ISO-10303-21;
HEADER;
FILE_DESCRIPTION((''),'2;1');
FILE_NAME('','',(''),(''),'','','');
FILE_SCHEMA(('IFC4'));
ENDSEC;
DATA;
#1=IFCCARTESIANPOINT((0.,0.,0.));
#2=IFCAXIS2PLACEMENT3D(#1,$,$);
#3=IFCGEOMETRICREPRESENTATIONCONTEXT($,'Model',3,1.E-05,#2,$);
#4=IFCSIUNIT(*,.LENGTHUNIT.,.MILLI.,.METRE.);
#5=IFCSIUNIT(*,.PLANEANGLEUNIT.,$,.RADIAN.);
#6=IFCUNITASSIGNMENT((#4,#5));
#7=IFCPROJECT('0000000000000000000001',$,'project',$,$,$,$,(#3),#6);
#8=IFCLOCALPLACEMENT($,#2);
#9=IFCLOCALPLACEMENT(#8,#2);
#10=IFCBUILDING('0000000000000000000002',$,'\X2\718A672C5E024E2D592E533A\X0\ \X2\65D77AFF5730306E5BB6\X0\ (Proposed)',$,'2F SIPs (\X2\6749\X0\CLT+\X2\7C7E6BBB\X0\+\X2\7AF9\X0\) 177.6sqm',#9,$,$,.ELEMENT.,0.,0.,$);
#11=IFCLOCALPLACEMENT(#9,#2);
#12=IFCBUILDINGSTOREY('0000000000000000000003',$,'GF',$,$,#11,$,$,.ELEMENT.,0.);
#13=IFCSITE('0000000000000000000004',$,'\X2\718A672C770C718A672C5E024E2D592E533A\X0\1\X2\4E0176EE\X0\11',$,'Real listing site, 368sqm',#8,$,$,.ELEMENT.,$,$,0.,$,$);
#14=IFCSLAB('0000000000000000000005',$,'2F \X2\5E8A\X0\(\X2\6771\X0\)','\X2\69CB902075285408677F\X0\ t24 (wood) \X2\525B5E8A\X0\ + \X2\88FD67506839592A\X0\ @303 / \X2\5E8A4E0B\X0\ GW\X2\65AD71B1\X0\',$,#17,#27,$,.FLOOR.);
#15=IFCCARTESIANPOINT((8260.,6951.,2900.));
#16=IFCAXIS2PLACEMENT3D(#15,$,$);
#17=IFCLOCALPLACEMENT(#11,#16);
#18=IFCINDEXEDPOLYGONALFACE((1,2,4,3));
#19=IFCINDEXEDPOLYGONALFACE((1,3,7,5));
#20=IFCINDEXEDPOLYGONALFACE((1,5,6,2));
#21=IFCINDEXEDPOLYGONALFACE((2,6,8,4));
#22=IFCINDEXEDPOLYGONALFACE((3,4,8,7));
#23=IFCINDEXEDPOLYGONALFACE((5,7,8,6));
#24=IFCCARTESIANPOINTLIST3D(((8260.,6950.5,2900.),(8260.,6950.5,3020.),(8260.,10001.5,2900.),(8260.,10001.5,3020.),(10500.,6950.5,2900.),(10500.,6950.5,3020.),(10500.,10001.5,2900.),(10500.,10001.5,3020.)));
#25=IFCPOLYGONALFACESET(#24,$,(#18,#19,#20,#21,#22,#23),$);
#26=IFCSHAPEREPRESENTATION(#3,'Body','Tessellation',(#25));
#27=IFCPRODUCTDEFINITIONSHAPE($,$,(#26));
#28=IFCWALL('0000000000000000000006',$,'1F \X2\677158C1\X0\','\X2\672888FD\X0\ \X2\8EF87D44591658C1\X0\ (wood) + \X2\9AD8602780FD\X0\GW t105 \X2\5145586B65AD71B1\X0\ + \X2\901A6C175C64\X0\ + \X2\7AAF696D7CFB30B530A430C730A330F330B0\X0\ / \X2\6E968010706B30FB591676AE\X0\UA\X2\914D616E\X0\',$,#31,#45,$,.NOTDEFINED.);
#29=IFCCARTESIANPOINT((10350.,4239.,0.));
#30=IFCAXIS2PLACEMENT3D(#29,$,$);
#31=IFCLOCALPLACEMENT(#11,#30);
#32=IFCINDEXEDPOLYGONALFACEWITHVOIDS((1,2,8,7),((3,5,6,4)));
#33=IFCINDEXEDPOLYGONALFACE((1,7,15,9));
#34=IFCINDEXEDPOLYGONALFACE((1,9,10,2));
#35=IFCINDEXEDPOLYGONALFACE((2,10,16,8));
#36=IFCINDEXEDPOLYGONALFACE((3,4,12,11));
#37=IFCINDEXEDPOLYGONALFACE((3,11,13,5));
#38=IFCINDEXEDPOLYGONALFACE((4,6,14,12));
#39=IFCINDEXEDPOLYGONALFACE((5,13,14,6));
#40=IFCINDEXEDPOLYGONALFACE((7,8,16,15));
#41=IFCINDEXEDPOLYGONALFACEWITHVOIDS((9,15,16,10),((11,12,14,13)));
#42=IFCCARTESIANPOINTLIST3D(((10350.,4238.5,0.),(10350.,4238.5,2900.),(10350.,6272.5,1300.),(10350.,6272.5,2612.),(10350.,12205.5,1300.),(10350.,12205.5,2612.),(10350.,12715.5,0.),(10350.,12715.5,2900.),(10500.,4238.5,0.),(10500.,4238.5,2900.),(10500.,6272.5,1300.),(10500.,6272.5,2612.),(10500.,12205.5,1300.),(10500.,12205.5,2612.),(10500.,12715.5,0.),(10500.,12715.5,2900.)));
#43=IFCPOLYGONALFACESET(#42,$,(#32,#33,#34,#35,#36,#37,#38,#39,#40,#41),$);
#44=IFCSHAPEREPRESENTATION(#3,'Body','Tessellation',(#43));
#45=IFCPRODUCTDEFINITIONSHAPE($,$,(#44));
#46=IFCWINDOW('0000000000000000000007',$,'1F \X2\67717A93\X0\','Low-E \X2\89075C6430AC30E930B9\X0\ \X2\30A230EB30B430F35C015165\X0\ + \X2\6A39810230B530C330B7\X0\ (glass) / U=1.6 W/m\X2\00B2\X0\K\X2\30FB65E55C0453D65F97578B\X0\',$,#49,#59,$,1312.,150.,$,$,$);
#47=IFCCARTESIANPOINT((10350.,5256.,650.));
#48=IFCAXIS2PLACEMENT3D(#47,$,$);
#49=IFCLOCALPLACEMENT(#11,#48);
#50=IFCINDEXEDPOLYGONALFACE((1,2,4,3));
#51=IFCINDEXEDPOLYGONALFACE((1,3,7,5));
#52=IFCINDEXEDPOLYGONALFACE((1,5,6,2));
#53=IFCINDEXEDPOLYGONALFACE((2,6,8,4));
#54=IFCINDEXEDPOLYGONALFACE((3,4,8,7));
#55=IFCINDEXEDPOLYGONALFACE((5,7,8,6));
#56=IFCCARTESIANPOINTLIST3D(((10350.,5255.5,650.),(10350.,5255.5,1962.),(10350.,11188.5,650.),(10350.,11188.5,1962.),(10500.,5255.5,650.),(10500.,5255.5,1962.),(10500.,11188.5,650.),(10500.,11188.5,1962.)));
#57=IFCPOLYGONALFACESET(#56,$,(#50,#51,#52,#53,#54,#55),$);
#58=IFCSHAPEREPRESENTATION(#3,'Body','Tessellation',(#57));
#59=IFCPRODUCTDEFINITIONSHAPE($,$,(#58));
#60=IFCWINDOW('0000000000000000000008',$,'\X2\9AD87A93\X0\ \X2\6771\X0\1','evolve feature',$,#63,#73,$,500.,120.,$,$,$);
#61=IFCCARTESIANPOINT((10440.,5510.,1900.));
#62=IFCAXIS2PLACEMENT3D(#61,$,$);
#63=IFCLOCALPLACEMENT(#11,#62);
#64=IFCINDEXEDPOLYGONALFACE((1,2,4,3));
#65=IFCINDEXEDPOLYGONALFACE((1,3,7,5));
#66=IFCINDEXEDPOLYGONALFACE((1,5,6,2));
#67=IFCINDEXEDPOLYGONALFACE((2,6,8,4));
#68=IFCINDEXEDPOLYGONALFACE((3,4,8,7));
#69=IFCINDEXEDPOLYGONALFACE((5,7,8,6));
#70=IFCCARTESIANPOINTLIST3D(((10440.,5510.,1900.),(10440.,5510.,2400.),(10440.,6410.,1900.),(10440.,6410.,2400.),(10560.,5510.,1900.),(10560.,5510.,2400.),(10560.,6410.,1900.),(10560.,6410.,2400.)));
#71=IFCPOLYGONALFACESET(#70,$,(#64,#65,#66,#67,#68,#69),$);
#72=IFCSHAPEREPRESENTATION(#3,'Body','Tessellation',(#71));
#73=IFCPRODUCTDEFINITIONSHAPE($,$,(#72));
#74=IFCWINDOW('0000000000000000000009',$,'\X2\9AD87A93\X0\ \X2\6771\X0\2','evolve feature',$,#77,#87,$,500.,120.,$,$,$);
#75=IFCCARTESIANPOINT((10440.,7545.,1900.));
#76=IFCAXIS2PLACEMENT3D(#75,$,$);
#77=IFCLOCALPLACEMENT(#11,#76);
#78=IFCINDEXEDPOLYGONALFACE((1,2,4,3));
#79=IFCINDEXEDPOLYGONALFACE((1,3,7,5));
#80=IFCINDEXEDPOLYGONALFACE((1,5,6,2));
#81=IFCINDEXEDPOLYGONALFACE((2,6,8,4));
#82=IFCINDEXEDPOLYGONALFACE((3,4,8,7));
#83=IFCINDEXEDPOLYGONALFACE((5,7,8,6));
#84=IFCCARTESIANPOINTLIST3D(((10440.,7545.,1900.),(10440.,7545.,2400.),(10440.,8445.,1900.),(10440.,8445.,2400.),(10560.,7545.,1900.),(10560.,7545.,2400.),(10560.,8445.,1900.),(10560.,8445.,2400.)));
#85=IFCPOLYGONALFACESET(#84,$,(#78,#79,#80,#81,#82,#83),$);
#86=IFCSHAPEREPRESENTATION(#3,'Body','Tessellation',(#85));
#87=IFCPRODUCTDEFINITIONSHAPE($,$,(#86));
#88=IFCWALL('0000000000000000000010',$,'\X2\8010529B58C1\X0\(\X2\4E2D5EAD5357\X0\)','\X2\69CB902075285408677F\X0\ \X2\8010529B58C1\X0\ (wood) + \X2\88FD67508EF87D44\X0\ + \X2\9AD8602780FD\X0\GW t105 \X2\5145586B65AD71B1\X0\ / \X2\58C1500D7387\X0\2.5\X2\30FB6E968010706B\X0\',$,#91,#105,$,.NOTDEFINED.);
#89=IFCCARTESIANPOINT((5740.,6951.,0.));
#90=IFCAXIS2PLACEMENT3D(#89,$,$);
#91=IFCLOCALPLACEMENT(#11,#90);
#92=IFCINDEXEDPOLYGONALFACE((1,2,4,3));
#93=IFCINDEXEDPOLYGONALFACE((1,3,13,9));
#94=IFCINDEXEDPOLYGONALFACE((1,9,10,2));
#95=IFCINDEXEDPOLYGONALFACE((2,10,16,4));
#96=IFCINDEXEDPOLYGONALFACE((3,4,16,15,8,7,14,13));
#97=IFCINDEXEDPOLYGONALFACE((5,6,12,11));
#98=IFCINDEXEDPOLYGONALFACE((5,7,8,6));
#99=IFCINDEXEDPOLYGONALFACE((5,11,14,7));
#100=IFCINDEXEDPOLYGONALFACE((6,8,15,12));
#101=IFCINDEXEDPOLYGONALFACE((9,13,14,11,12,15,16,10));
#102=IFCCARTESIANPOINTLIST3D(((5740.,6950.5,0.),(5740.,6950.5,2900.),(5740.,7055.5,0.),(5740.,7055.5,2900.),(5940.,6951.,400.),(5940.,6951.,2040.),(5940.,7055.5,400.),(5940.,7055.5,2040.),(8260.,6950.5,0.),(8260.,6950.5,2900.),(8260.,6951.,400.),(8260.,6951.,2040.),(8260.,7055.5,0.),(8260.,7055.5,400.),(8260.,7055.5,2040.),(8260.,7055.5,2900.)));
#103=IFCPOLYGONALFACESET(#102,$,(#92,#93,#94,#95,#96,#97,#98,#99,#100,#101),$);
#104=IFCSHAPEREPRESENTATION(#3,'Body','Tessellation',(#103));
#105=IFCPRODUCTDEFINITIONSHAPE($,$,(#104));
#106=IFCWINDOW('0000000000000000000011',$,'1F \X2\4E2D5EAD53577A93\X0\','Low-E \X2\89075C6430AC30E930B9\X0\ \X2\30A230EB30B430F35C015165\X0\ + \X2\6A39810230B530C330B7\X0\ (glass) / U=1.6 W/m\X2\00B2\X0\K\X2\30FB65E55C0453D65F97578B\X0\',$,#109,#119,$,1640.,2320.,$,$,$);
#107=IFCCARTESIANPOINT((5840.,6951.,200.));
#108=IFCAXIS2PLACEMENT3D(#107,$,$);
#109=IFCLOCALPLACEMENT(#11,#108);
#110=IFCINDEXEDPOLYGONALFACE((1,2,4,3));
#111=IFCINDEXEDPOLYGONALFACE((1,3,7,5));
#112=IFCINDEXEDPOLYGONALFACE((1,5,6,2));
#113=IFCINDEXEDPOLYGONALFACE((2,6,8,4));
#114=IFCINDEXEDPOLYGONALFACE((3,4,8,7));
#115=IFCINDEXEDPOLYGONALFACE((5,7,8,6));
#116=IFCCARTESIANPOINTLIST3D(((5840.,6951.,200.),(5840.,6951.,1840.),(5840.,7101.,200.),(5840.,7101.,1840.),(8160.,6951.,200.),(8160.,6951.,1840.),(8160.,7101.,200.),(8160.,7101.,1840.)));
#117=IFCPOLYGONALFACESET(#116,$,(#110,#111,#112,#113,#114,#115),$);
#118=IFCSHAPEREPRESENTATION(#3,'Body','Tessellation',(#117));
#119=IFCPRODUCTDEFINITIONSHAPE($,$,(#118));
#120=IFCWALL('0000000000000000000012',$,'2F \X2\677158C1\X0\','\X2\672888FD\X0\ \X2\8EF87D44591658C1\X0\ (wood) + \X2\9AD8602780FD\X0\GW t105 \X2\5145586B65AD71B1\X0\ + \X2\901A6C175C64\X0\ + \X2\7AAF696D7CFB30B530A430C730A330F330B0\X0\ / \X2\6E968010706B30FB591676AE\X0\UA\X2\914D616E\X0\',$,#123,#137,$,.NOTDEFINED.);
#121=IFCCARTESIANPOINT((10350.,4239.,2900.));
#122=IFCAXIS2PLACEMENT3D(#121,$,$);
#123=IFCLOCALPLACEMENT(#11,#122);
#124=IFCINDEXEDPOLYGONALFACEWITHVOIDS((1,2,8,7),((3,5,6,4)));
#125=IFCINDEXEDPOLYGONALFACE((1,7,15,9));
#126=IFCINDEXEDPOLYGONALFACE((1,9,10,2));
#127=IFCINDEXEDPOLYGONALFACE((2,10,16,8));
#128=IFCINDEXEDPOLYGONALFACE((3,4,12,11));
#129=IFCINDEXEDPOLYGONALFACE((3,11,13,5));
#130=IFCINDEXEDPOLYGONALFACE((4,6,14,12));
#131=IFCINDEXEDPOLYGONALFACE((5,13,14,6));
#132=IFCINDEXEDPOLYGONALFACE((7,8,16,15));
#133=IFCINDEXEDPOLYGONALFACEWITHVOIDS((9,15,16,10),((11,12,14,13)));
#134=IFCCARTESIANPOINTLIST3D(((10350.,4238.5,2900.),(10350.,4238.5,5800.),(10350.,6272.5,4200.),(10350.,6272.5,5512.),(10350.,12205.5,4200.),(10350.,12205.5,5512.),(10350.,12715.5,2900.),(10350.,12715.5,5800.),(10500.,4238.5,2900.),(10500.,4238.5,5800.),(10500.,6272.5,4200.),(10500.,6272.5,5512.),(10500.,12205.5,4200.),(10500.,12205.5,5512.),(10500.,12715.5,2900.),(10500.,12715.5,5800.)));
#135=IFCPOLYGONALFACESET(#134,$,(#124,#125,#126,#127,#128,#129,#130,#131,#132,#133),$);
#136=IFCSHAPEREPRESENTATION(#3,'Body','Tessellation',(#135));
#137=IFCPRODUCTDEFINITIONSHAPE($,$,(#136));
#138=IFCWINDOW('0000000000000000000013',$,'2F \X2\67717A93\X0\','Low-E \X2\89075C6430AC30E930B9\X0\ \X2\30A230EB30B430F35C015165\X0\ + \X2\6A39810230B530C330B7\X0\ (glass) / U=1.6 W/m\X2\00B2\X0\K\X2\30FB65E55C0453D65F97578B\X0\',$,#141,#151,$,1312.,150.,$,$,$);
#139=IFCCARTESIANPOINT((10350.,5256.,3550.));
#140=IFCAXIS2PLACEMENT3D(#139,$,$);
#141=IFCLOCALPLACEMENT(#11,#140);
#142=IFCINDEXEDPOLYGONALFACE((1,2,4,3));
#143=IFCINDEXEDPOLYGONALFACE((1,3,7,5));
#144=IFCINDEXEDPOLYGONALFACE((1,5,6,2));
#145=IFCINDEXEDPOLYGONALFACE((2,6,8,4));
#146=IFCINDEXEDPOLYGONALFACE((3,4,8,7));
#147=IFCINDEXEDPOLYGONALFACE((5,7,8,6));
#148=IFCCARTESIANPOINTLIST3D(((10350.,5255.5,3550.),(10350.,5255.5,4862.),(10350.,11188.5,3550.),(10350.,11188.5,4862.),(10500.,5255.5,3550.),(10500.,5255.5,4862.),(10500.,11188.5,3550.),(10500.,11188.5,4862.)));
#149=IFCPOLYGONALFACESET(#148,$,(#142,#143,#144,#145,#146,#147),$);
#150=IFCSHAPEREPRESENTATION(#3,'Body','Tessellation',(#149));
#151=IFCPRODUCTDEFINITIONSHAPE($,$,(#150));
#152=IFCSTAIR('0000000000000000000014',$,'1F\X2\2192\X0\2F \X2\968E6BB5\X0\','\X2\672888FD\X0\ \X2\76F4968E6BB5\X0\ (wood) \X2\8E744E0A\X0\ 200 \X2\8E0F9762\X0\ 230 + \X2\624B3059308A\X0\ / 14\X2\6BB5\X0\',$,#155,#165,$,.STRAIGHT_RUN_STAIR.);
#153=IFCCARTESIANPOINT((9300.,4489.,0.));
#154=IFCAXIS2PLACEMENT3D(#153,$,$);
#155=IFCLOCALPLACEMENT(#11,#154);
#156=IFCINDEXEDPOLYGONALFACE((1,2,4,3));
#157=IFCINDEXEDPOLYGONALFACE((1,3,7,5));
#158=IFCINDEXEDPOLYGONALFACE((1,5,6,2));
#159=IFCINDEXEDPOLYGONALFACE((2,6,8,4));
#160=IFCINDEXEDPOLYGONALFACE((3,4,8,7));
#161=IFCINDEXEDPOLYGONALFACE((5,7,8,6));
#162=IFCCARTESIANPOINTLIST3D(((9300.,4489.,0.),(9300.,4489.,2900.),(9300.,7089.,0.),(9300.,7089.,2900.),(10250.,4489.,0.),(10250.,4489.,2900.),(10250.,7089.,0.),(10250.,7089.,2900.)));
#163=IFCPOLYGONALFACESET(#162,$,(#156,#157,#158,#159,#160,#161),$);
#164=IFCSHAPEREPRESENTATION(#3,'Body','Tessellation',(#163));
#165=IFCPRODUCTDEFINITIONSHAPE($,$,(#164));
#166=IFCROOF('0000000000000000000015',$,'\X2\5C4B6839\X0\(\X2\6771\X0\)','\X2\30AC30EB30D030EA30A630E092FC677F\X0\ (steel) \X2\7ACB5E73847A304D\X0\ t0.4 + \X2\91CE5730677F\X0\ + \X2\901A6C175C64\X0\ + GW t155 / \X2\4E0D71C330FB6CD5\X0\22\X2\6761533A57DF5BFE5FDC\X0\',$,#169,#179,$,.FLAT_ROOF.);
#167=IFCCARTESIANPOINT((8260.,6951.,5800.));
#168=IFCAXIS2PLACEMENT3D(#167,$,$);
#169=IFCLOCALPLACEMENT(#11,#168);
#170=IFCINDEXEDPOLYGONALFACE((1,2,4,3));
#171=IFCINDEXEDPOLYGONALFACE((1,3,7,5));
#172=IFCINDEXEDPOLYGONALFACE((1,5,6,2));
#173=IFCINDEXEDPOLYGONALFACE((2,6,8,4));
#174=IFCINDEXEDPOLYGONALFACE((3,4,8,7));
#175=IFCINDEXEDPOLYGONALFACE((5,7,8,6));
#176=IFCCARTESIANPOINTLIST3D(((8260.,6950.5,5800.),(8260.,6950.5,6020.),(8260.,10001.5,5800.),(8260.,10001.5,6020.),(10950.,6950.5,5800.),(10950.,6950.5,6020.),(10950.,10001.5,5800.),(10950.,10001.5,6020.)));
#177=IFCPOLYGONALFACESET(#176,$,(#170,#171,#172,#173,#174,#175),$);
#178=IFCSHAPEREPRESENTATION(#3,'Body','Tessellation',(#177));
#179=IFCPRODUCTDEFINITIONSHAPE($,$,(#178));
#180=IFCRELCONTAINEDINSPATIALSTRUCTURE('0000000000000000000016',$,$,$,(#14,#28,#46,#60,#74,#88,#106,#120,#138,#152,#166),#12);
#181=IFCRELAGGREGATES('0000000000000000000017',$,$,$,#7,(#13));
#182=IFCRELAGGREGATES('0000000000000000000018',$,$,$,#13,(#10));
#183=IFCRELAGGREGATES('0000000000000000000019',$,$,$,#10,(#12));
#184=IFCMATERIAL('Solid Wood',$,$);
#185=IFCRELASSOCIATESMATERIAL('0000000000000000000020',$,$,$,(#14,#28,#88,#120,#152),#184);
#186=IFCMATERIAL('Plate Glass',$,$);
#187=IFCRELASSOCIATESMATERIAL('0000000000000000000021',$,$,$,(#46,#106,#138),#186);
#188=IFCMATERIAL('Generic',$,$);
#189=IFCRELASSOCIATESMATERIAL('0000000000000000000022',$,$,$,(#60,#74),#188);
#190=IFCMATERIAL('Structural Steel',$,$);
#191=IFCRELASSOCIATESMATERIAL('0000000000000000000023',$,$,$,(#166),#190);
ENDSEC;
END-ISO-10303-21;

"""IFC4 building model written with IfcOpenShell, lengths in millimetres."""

from ifc_helpers import new_model, si_unit, frame, frame_2d, origin, place, context, project, spatial, rectangle, extrude, material, element, fill, save


model = new_model("IFC4")

# Units and contexts
model_context = context("Model", 3, precision=1e-05, world=origin())
ifc_project = project(units=[si_unit("LENGTHUNIT", "METRE", prefix="MILLI"), si_unit("PLANEANGLEUNIT", "RADIAN")], contexts=[model_context])

# Site, building, storey
site_placement = place(None, origin())
site = spatial("IfcSite", under=ifc_project, at=site_placement, Name="熊本県熊本市中央区1丁目11", ObjectType="Real listing site, 368sqm", CompositionType="ELEMENT", RefElevation=0.0)
building_placement = place(site_placement, origin())
building = spatial("IfcBuilding", under=site, at=building_placement, Name="熊本市中央区 旗竿地の家 (Proposed)", ObjectType="2F SIPs (杉CLT+籾殻+竹) 177.6sqm", CompositionType="ELEMENT", ElevationOfRefHeight=0.0, ElevationOfTerrain=0.0)
storey_placement = place(building_placement, origin())
storey = spatial("IfcBuildingStorey", under=building, at=storey_placement, Name="GF", CompositionType="ELEMENT", Elevation=0.0)

# Slab
ifc_material_1 = material(Name="Solid Wood")
slab_1_placement = place(storey_placement, frame((8260.0, 6951.0, 2900.0)))
element("IfcSlab", 1, at=slab_1_placement, inside=storey, material=ifc_material_1, Name="2F 床(東)", Description="構造用合板 t24 (wood) 剛床 + 製材根太 @303 / 床下 GW断熱", PredefinedType="FLOOR", context=model_context, shape_type="SweptSolid", body=[
    extrude(rectangle(XDim=2240.0, YDim=3051.0, at=frame_2d((1120.0, 1525.0))), frame((8260.0, 6951.0, 2900.0)), (0.0, 0.0, 1.0), 120.0),
])

# Wall, openings, windows
wall_1_placement = place(storey_placement, frame((10350.0, 4239.0, 0.0)))
wall_1 = element("IfcWall", 2, at=wall_1_placement, inside=storey, material=ifc_material_1, Name="1F 東壁", Description="木製 軸組外壁 (wood) + 高性能GW t105 充填断熱 + 通気層 + 窯業系サイディング / 準耐火・外皮UA配慮", PredefinedType="NOTDEFINED", context=model_context, shape_type="SweptSolid", body=[
    extrude(rectangle(XDim=150.0, YDim=8477.0, at=frame_2d((75.0, 4238.0))), frame((10350.0, 4239.0, 0.0)), (0.0, 0.0, 1.0), 2900.0),
])
opening_1_placement = place(storey_placement, frame((10350.0, 5256.0, 650.0)))
opening_1 = element("IfcOpeningElement", 3, at=opening_1_placement, cuts=wall_1, PredefinedType="NOTDEFINED", context=model_context, shape_type="SweptSolid", body=[
    extrude(rectangle(XDim=150.0, YDim=5933.0, at=frame_2d((75.0, 2966.0))), frame((10350.0, 5256.0, 650.0)), (0.0, 0.0, 1.0), 1312.0),
])
opening_2_placement = place(storey_placement, frame((10440.0, 5510.0, 1900.0)))
opening_2 = element("IfcOpeningElement", 4, at=opening_2_placement, cuts=wall_1, PredefinedType="NOTDEFINED", context=model_context, shape_type="SweptSolid", body=[
    extrude(rectangle(XDim=120.0, YDim=900.0, at=frame_2d((60.0, 450.0))), frame((10440.0, 5510.0, 1900.0)), (0.0, 0.0, 1.0), 500.0),
])
opening_3_placement = place(storey_placement, frame((10440.0, 7545.0, 1900.0)))
opening_3 = element("IfcOpeningElement", 5, at=opening_3_placement, cuts=wall_1, PredefinedType="NOTDEFINED", context=model_context, shape_type="SweptSolid", body=[
    extrude(rectangle(XDim=120.0, YDim=900.0, at=frame_2d((60.0, 450.0))), frame((10440.0, 7545.0, 1900.0)), (0.0, 0.0, 1.0), 500.0),
])
ifc_material_2 = material(Name="Plate Glass")
window_1_placement = place(storey_placement, frame((10350.0, 5256.0, 650.0)))
window_1 = element("IfcWindow", 6, at=window_1_placement, inside=storey, material=ifc_material_2, Name="1F 東窓", Description="Low-E 複層ガラス アルゴン封入 + 樹脂サッシ (glass) / U=1.6 W/m²K・日射取得型", OverallHeight=1312.0, OverallWidth=150.0, context=model_context, shape_type="SweptSolid", body=[
    extrude(rectangle(XDim=150.0, YDim=5933.0, at=frame_2d((75.0, 2966.0))), frame((10350.0, 5256.0, 650.0)), (0.0, 0.0, 1.0), 1312.0),
])
fill(opening_1, window_1)
ifc_material_3 = material(Name="Generic")
window_2_placement = place(storey_placement, frame((10440.0, 5510.0, 1900.0)))
window_2 = element("IfcWindow", 7, at=window_2_placement, inside=storey, material=ifc_material_3, Name="高窓 東1", Description="evolve feature", OverallHeight=500.0, OverallWidth=120.0, context=model_context, shape_type="SweptSolid", body=[
    extrude(rectangle(XDim=120.0, YDim=900.0, at=frame_2d((60.0, 450.0))), frame((10440.0, 5510.0, 1900.0)), (0.0, 0.0, 1.0), 500.0),
])
fill(opening_2, window_2)
window_3_placement = place(storey_placement, frame((10440.0, 7545.0, 1900.0)))
window_3 = element("IfcWindow", 8, at=window_3_placement, inside=storey, material=ifc_material_3, Name="高窓 東2", Description="evolve feature", OverallHeight=500.0, OverallWidth=120.0, context=model_context, shape_type="SweptSolid", body=[
    extrude(rectangle(XDim=120.0, YDim=900.0, at=frame_2d((60.0, 450.0))), frame((10440.0, 7545.0, 1900.0)), (0.0, 0.0, 1.0), 500.0),
])
fill(opening_3, window_3)

# Wall, opening, window
wall_2_placement = place(storey_placement, frame((5740.0, 6951.0, 0.0)))
wall_2 = element("IfcWall", 9, at=wall_2_placement, inside=storey, material=ifc_material_1, Name="耐力壁(中庭南)", Description="構造用合板 耐力壁 (wood) + 製材軸組 + 高性能GW t105 充填断熱 / 壁倍率2.5・準耐火", PredefinedType="NOTDEFINED", context=model_context, shape_type="SweptSolid", body=[
    extrude(rectangle(XDim=2520.0, YDim=105.0, at=frame_2d((1260.0, 52.0))), frame((5740.0, 6951.0, 0.0)), (0.0, 0.0, 1.0), 2900.0),
])
opening_4_placement = place(storey_placement, frame((5840.0, 6951.0, 200.0)))
opening_4 = element("IfcOpeningElement", 10, at=opening_4_placement, cuts=wall_2, PredefinedType="NOTDEFINED", context=model_context, shape_type="SweptSolid", body=[
    extrude(rectangle(XDim=2320.0, YDim=150.0, at=frame_2d((1160.0, 75.0))), frame((5840.0, 6951.0, 200.0)), (0.0, 0.0, 1.0), 1640.0),
])
window_4_placement = place(storey_placement, frame((5840.0, 6951.0, 200.0)))
window_4 = element("IfcWindow", 11, at=window_4_placement, inside=storey, material=ifc_material_2, Name="1F 中庭南窓", Description="Low-E 複層ガラス アルゴン封入 + 樹脂サッシ (glass) / U=1.6 W/m²K・日射取得型", OverallHeight=1640.0, OverallWidth=2320.0, context=model_context, shape_type="SweptSolid", body=[
    extrude(rectangle(XDim=2320.0, YDim=150.0, at=frame_2d((1160.0, 75.0))), frame((5840.0, 6951.0, 200.0)), (0.0, 0.0, 1.0), 1640.0),
])
fill(opening_4, window_4)

# Wall, opening, window
wall_3_placement = place(storey_placement, frame((10350.0, 4239.0, 2900.0)))
wall_3 = element("IfcWall", 12, at=wall_3_placement, inside=storey, material=ifc_material_1, Name="2F 東壁", Description="木製 軸組外壁 (wood) + 高性能GW t105 充填断熱 + 通気層 + 窯業系サイディング / 準耐火・外皮UA配慮", PredefinedType="NOTDEFINED", context=model_context, shape_type="SweptSolid", body=[
    extrude(rectangle(XDim=150.0, YDim=8477.0, at=frame_2d((75.0, 4238.0))), frame((10350.0, 4239.0, 2900.0)), (0.0, 0.0, 1.0), 2900.0),
])
opening_5_placement = place(storey_placement, frame((10350.0, 5256.0, 3550.0)))
opening_5 = element("IfcOpeningElement", 13, at=opening_5_placement, cuts=wall_3, PredefinedType="NOTDEFINED", context=model_context, shape_type="SweptSolid", body=[
    extrude(rectangle(XDim=150.0, YDim=5933.0, at=frame_2d((75.0, 2966.0))), frame((10350.0, 5256.0, 3550.0)), (0.0, 0.0, 1.0), 1312.0),
])
window_5_placement = place(storey_placement, frame((10350.0, 5256.0, 3550.0)))
window_5 = element("IfcWindow", 14, at=window_5_placement, inside=storey, material=ifc_material_2, Name="2F 東窓", Description="Low-E 複層ガラス アルゴン封入 + 樹脂サッシ (glass) / U=1.6 W/m²K・日射取得型", OverallHeight=1312.0, OverallWidth=150.0, context=model_context, shape_type="SweptSolid", body=[
    extrude(rectangle(XDim=150.0, YDim=5933.0, at=frame_2d((75.0, 2966.0))), frame((10350.0, 5256.0, 3550.0)), (0.0, 0.0, 1.0), 1312.0),
])
fill(opening_5, window_5)

# Stair
stair_placement = place(storey_placement, frame((9300.0, 4489.0, 0.0)))
element("IfcStair", 15, at=stair_placement, inside=storey, material=ifc_material_1, Name="1F→2F 階段", Description="木製 直階段 (wood) 蹴上 200 踏面 230 + 手すり / 14段", PredefinedType="STRAIGHT_RUN_STAIR", context=model_context, shape_type="SweptSolid", body=[
    extrude(rectangle(XDim=950.0, YDim=2600.0, at=frame_2d((475.0, 1300.0))), frame((9300.0, 4489.0, 0.0)), (0.0, 0.0, 1.0), 2900.0),
])

# Roof
ifc_material_4 = material(Name="Structural Steel")
roof_placement = place(storey_placement, frame((8260.0, 6951.0, 5800.0)))
element("IfcRoof", 16, at=roof_placement, inside=storey, material=ifc_material_4, Name="屋根(東)", Description="ガルバリウム鋼板 (steel) 立平葺き t0.4 + 野地板 + 通気層 + GW t155 / 不燃・法22条区域対応", PredefinedType="FLAT_ROOF", context=model_context, shape_type="SweptSolid", body=[
    extrude(rectangle(XDim=2690.0, YDim=3051.0, at=frame_2d((1345.0, 1525.0))), frame((8260.0, 6951.0, 5800.0)), (0.0, 0.0, 1.0), 220.0),
])

save(model, "model.ifc")
